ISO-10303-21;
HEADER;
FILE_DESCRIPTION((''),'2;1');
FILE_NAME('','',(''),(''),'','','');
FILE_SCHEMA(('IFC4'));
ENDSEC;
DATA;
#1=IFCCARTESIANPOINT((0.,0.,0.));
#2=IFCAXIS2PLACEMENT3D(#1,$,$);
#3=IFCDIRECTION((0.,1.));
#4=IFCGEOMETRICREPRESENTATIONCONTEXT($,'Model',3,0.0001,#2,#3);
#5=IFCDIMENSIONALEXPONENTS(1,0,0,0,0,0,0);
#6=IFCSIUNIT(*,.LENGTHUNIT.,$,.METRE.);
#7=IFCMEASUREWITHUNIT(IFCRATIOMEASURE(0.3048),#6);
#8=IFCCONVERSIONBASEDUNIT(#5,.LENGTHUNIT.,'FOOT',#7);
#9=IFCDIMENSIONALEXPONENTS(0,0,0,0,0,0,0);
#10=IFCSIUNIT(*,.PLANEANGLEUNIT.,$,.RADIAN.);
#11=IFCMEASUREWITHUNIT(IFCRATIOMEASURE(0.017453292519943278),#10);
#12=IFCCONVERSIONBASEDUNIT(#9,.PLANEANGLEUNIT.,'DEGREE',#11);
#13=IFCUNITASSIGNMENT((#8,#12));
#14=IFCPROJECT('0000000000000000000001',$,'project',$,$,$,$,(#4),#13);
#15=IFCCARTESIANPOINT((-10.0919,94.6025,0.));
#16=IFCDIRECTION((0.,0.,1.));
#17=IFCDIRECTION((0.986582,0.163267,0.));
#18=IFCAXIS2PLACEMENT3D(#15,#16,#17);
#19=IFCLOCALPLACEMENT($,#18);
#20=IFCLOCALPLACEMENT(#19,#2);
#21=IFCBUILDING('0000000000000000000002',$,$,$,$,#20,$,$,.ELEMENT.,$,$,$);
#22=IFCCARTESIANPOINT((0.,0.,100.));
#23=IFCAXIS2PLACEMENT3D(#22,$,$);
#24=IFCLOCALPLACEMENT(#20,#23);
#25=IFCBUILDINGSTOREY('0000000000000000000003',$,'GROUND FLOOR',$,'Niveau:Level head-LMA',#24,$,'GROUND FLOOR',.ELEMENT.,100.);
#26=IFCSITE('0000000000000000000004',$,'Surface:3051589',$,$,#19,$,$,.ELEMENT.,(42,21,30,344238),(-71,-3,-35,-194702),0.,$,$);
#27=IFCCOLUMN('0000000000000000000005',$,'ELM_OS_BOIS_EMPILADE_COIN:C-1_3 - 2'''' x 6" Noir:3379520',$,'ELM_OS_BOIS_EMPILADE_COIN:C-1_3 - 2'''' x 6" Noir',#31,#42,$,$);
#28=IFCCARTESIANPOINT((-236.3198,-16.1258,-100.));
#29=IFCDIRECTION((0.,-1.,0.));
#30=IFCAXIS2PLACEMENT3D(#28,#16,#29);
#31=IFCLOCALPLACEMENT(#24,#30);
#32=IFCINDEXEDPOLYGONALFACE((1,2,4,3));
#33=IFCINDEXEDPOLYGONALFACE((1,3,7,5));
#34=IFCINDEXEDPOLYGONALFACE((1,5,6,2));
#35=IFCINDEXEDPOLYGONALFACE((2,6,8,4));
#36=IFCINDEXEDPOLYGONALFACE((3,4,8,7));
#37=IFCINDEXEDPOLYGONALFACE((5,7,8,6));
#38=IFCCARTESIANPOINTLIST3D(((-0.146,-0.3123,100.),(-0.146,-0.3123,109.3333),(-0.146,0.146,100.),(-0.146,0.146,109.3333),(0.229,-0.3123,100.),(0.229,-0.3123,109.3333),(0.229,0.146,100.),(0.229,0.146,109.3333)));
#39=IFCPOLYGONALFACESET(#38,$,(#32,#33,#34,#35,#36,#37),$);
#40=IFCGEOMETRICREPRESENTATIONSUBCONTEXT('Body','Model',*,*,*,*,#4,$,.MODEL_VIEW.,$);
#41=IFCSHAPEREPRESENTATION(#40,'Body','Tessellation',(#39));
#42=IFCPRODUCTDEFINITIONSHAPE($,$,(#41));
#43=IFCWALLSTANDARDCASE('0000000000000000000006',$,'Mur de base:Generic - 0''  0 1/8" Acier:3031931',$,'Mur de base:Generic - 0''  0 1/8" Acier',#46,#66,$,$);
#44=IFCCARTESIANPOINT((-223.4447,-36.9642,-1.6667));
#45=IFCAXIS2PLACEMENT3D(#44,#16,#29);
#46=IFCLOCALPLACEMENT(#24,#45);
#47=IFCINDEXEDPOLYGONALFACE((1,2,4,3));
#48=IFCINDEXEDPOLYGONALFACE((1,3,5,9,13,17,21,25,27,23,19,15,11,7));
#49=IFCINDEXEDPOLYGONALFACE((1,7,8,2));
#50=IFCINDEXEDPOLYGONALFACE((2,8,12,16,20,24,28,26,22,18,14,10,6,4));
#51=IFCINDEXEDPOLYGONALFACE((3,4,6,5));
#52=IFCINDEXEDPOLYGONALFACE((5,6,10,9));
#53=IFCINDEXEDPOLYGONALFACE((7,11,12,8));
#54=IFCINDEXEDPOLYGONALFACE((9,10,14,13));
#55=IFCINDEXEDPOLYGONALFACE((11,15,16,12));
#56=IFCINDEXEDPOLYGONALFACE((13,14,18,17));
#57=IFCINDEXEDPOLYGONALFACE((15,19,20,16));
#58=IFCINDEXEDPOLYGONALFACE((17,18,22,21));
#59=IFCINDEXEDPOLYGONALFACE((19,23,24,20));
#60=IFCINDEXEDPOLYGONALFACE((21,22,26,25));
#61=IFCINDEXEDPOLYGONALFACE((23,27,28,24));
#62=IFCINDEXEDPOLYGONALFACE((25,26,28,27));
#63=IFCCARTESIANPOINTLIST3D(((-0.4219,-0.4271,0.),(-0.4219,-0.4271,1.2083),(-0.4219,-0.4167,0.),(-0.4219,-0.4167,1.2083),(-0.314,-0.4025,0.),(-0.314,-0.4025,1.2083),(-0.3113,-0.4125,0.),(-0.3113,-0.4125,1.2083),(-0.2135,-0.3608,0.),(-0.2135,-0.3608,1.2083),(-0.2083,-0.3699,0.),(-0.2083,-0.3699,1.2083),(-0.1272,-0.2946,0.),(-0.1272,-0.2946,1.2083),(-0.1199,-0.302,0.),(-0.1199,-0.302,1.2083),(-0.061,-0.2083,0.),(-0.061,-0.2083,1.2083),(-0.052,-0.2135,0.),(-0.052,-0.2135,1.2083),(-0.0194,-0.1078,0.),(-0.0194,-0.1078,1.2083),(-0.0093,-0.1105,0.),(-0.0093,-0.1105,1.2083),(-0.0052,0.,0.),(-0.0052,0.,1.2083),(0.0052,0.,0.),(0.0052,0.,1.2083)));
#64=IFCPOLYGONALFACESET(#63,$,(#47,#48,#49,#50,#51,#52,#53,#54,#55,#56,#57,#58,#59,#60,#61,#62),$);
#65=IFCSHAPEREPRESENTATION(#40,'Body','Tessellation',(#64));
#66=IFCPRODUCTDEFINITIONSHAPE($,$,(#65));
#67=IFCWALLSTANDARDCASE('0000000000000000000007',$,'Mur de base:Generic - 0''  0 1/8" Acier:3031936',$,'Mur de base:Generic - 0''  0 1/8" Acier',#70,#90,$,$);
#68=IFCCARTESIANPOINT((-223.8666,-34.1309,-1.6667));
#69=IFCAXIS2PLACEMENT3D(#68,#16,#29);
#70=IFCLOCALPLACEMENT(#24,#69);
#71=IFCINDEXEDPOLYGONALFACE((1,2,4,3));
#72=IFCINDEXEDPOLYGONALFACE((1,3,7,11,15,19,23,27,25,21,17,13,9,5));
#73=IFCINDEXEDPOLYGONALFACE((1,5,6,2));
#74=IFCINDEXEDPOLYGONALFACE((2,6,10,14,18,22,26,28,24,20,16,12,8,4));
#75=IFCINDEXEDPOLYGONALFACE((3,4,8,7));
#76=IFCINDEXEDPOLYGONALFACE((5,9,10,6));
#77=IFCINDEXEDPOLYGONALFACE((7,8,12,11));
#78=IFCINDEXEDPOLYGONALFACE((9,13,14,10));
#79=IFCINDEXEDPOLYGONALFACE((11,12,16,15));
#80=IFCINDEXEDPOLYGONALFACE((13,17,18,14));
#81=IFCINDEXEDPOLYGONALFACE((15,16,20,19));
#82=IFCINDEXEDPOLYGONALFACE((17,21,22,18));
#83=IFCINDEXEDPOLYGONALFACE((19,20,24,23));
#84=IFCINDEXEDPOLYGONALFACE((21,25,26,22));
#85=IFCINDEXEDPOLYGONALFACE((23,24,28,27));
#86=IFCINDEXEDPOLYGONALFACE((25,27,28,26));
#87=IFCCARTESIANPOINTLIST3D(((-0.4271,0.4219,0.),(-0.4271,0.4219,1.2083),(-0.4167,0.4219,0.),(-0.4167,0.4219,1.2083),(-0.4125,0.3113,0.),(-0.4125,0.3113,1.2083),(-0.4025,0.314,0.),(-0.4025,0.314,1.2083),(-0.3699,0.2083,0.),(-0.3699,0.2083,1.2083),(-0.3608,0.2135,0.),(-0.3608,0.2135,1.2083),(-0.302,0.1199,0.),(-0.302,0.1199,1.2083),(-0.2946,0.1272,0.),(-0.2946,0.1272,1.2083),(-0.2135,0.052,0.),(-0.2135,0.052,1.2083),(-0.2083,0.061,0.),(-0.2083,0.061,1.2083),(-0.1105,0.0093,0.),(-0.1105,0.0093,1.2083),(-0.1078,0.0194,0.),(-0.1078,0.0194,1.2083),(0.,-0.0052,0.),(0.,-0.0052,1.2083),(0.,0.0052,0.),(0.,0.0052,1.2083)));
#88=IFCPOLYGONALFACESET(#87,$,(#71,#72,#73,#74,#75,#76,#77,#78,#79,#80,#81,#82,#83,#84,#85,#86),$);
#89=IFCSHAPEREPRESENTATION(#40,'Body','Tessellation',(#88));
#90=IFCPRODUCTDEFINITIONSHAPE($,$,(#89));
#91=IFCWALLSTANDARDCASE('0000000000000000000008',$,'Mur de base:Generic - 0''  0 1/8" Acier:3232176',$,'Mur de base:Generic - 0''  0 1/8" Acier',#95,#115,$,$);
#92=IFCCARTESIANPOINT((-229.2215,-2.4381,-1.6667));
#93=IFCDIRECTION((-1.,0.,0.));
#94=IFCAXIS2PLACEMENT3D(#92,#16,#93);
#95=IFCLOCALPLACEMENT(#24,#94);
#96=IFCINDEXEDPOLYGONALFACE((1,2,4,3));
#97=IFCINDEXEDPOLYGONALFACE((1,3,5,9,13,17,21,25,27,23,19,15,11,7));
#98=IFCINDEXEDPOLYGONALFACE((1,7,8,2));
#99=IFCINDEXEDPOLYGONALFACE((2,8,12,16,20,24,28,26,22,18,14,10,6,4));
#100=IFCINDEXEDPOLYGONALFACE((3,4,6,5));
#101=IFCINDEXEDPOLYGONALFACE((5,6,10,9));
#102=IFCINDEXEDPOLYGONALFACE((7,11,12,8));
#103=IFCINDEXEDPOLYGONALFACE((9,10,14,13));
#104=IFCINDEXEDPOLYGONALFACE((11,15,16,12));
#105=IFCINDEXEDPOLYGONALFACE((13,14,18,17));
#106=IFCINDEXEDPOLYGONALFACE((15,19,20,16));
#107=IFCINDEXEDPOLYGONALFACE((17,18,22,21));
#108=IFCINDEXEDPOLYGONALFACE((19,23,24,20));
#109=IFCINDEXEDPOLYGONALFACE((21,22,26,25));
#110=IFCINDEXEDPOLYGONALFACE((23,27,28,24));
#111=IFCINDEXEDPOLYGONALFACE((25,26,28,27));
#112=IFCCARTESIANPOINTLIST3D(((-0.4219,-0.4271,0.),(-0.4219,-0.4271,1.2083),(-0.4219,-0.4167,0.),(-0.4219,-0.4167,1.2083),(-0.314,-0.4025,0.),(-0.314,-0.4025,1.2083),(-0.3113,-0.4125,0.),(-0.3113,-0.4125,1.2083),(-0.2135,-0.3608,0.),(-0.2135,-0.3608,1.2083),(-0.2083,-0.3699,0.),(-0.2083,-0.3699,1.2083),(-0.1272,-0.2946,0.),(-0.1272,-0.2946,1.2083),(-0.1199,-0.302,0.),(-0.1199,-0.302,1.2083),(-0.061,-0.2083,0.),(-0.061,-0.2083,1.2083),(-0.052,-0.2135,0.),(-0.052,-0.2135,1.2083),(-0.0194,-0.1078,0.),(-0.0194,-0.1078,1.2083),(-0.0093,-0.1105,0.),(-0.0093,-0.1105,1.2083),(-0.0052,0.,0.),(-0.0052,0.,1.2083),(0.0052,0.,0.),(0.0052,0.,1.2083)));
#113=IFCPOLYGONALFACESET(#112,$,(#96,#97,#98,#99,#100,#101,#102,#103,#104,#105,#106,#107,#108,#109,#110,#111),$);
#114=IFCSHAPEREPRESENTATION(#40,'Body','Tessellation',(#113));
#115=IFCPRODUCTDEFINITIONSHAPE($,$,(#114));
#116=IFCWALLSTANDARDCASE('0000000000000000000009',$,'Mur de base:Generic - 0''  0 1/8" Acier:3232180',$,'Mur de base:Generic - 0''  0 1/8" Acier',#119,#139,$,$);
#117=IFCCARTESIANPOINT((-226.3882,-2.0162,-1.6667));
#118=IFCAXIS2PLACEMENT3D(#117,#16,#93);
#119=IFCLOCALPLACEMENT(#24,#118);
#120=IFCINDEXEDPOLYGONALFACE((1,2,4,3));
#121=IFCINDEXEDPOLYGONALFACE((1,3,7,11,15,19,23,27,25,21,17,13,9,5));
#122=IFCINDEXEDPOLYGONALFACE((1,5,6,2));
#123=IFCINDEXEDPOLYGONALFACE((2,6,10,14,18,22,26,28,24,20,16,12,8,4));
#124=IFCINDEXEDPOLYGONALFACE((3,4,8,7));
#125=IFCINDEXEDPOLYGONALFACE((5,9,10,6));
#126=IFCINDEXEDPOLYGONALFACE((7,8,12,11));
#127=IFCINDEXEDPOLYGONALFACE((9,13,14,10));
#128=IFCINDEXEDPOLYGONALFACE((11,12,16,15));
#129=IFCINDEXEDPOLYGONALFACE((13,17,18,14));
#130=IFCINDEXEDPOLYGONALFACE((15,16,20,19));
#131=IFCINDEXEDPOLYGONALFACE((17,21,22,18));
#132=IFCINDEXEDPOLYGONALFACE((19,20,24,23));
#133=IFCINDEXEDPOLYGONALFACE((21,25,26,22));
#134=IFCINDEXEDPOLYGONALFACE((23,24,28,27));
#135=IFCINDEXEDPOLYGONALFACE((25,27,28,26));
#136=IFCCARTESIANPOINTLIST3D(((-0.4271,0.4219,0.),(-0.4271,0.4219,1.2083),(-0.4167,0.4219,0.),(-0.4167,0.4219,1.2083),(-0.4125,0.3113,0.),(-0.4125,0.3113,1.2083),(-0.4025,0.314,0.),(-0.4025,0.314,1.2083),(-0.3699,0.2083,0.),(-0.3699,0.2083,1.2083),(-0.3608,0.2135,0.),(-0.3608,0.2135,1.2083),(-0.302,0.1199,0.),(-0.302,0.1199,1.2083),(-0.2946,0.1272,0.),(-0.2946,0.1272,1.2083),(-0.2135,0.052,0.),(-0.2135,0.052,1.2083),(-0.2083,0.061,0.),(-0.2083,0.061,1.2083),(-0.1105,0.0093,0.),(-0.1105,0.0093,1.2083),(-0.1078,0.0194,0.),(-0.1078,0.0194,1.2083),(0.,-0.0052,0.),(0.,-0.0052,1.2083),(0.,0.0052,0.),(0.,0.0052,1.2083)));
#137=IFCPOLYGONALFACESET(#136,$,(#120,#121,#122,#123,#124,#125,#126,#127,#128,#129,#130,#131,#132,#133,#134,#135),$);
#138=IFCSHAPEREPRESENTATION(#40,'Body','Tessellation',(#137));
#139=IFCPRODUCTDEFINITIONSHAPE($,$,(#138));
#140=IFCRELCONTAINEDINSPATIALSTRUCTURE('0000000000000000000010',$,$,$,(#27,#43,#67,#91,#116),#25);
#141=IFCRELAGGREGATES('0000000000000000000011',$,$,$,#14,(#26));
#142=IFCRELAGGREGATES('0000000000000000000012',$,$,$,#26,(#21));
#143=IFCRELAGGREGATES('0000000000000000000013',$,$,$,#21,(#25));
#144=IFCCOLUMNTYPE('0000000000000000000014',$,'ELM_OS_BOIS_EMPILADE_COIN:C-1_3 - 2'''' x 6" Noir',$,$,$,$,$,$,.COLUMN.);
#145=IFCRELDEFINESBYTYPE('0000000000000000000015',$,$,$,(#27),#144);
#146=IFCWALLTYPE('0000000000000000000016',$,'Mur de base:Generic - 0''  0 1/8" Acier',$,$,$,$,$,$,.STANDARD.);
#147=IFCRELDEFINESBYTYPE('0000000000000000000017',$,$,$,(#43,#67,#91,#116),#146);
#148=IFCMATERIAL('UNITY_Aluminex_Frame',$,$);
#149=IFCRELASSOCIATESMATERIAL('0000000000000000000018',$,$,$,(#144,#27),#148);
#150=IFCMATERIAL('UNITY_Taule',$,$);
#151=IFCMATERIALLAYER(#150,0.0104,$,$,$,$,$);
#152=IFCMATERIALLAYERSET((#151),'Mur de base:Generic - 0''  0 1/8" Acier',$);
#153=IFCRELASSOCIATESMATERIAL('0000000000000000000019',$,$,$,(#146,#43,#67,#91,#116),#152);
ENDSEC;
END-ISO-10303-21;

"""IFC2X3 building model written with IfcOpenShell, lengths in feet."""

from ifc_helpers import new_model, entity, si_unit, converted_unit, direction, frame, frame_2d, origin, origin_2d_with_axis, place, context, subcontext, project, spatial, polyline, circle_curve, parameter, trimmed, segment, composite_curve, rectangle, outline, extrude, source, transform, mapped, material, layer, layer_set, layer_usage, type_object, type_shapes, element, save


model = new_model("IFC2X3")

# Units and contexts
model_context = context("Model", 3, precision=0.0001, world=origin(), true_north=direction((0.0, 1.0)))
body_context = subcontext(model_context, "Body", "Model", "MODEL_VIEW")
ifc_project = project(units=[converted_unit("LENGTHUNIT", "FOOT", entity("IfcRatioMeasure", 0.3048), si_unit("LENGTHUNIT", "METRE"), dimensions=[1, 0, 0, 0, 0, 0, 0]), converted_unit("PLANEANGLEUNIT", "DEGREE", entity("IfcRatioMeasure", 0.017453292519943278), si_unit("PLANEANGLEUNIT", "RADIAN"), dimensions=[0, 0, 0, 0, 0, 0, 0])], contexts=[model_context])

# Site, building, storey
site_placement = place(None, frame((-10.0919, 94.6025, 0.0), z_axis=(0.0, 0.0, 1.0), x_axis=(0.986582, 0.163267, 0.0)))
site = spatial("IfcSite", under=ifc_project, at=site_placement, Name="Surface:3051589", CompositionType="ELEMENT", RefLatitude=(42, 21, 30, 344238), RefLongitude=(-71, -3, -35, -194702), RefElevation=0.0)
building_placement = place(site_placement, origin())
building = spatial("IfcBuilding", under=site, at=building_placement, CompositionType="ELEMENT")
storey_placement = place(building_placement, frame((0.0, 0.0, 100.0)))
storey = spatial("IfcBuildingStorey", under=building, at=storey_placement, Name="GROUND FLOOR", ObjectType="Niveau:Level head-LMA", LongName="GROUND FLOOR", CompositionType="ELEMENT", Elevation=100.0)

# Column
ifc_material_1 = material(Name="UNITY_Aluminex_Frame")
column_type = type_object("IfcColumnType", Name="ELM_OS_BOIS_EMPILADE_COIN:C-1_3 - 2'' x 6\" Noir", PredefinedType="COLUMN", material=ifc_material_1)
shared_shape = source(origin(), body_context, "Body", "SweptSolid", [
    extrude(rectangle(XDim=0.4583, YDim=0.375, at=origin_2d_with_axis()), frame((0.0415, -0.0832, 100.0), z_axis=(0.0, 0.0, 1.0), x_axis=(0.0, -1.0, 0.0)), (0.0, 0.0, 1.0), 9.3333),
])
type_shapes(column_type, [shared_shape])
column_placement = place(storey_placement, frame((-236.3198, -16.1258, -100.0), z_axis=(0.0, 0.0, 1.0), x_axis=(0.0, -1.0, 0.0)))
element("IfcColumn", 1, at=column_placement, inside=storey, type_object=column_type, material=ifc_material_1, Name="ELM_OS_BOIS_EMPILADE_COIN:C-1_3 - 2'' x 6\" Noir:3379520", ObjectType="ELM_OS_BOIS_EMPILADE_COIN:C-1_3 - 2'' x 6\" Noir", context=body_context, shape_type="MappedRepresentation", body=[
    mapped(shared_shape, transform((0.0, 0.0, 0.0), scale=1.0)),
])

# Walls
ifc_material_2 = material(Name="UNITY_Taule")
ifc_layer_1 = layer(ifc_material_2, 0.0104)
ifc_layer_set_1 = layer_set([ifc_layer_1], Name="Mur de base:Generic - 0'  0 1/8\" Acier")
ifc_layer_usage_1 = layer_usage(ifc_layer_set_1, "AXIS2", "NEGATIVE", 0.0052)
wall_type_1 = type_object("IfcWallType", Name="Mur de base:Generic - 0'  0 1/8\" Acier", PredefinedType="STANDARD", material=ifc_layer_set_1)
wall_1_placement = place(storey_placement, frame((-223.4447, -36.9642, -1.6667), z_axis=(0.0, 0.0, 1.0), x_axis=(0.0, -1.0, 0.0)))
element("IfcWallStandardCase", 2, at=wall_1_placement, inside=storey, type_object=wall_type_1, material=ifc_layer_usage_1, Name="Mur de base:Generic - 0'  0 1/8\" Acier:3031931", ObjectType="Mur de base:Generic - 0'  0 1/8\" Acier", context=body_context, shape_type="SweptSolid", body=[
    extrude(outline(composite_curve([segment(trimmed(circle_curve(frame_2d((-0.4219, 0.0), x_axis=(1.0, 0.0)), 0.4271), [parameter(270.0)], [parameter(0.0)], True, "PARAMETER"), True, "CONTINUOUS"), segment(polyline([(0.0052, 0.0), (-0.0052, 0.0)]), True, "CONTINUOUS"), segment(trimmed(circle_curve(frame_2d((-0.4219, 0.0), x_axis=(1.0, 0.0)), 0.4167), [parameter(270.0)], [parameter(0.0)], True, "PARAMETER"), False, "CONTINUOUS"), segment(polyline([(-0.4219, -0.4167), (-0.4219, -0.4271)]), True, "CONTINUOUS")], self_intersect=False)), origin(), (0.0, 0.0, 1.0), 1.2083),
])
ifc_layer_usage_2 = layer_usage(ifc_layer_set_1, "AXIS2", "NEGATIVE", 0.0052)
wall_2_placement = place(storey_placement, frame((-223.8666, -34.1309, -1.6667), z_axis=(0.0, 0.0, 1.0), x_axis=(0.0, -1.0, 0.0)))
element("IfcWallStandardCase", 3, at=wall_2_placement, inside=storey, type_object=wall_type_1, material=ifc_layer_usage_2, Name="Mur de base:Generic - 0'  0 1/8\" Acier:3031936", ObjectType="Mur de base:Generic - 0'  0 1/8\" Acier", context=body_context, shape_type="SweptSolid", body=[
    extrude(outline(composite_curve([segment(trimmed(circle_curve(frame_2d((0.0, 0.4219), x_axis=(1.0, 0.0)), 0.4271), [parameter(180.0)], [parameter(270.0)], True, "PARAMETER"), True, "CONTINUOUS"), segment(polyline([(0.0, -0.0052), (0.0, 0.0052)]), True, "CONTINUOUS"), segment(trimmed(circle_curve(frame_2d((0.0, 0.4219), x_axis=(1.0, 0.0)), 0.4167), [parameter(180.0)], [parameter(270.0)], True, "PARAMETER"), False, "CONTINUOUS"), segment(polyline([(-0.4167, 0.4219), (-0.4271, 0.4219)]), True, "CONTINUOUS")], self_intersect=False)), origin(), (0.0, 0.0, 1.0), 1.2083),
])
ifc_layer_usage_3 = layer_usage(ifc_layer_set_1, "AXIS2", "NEGATIVE", 0.0052)
wall_3_placement = place(storey_placement, frame((-229.2215, -2.4381, -1.6667), z_axis=(0.0, 0.0, 1.0), x_axis=(-1.0, 0.0, 0.0)))
element("IfcWallStandardCase", 4, at=wall_3_placement, inside=storey, type_object=wall_type_1, material=ifc_layer_usage_3, Name="Mur de base:Generic - 0'  0 1/8\" Acier:3232176", ObjectType="Mur de base:Generic - 0'  0 1/8\" Acier", context=body_context, shape_type="SweptSolid", body=[
    extrude(outline(composite_curve([segment(trimmed(circle_curve(frame_2d((-0.4219, 0.0), x_axis=(1.0, 0.0)), 0.4271), [parameter(270.0)], [parameter(0.0)], True, "PARAMETER"), True, "CONTINUOUS"), segment(polyline([(0.0052, 0.0), (-0.0052, 0.0)]), True, "CONTINUOUS"), segment(trimmed(circle_curve(frame_2d((-0.4219, 0.0), x_axis=(1.0, 0.0)), 0.4167), [parameter(270.0)], [parameter(0.0)], True, "PARAMETER"), False, "CONTINUOUS"), segment(polyline([(-0.4219, -0.4167), (-0.4219, -0.4271)]), True, "CONTINUOUS")], self_intersect=False)), origin(), (0.0, 0.0, 1.0), 1.2083),
])
ifc_layer_usage_4 = layer_usage(ifc_layer_set_1, "AXIS2", "NEGATIVE", 0.0052)
wall_4_placement = place(storey_placement, frame((-226.3882, -2.0162, -1.6667), z_axis=(0.0, 0.0, 1.0), x_axis=(-1.0, 0.0, 0.0)))
element("IfcWallStandardCase", 5, at=wall_4_placement, inside=storey, type_object=wall_type_1, material=ifc_layer_usage_4, Name="Mur de base:Generic - 0'  0 1/8\" Acier:3232180", ObjectType="Mur de base:Generic - 0'  0 1/8\" Acier", context=body_context, shape_type="SweptSolid", body=[
    extrude(outline(composite_curve([segment(trimmed(circle_curve(frame_2d((0.0, 0.4219), x_axis=(1.0, 0.0)), 0.4271), [parameter(180.0)], [parameter(270.0)], True, "PARAMETER"), True, "CONTINUOUS"), segment(polyline([(0.0, -0.0052), (0.0, 0.0052)]), True, "CONTINUOUS"), segment(trimmed(circle_curve(frame_2d((0.0, 0.4219), x_axis=(1.0, 0.0)), 0.4167), [parameter(180.0)], [parameter(270.0)], True, "PARAMETER"), False, "CONTINUOUS"), segment(polyline([(-0.4167, 0.4219), (-0.4271, 0.4219)]), True, "CONTINUOUS")], self_intersect=False)), origin(), (0.0, 0.0, 1.0), 1.2083),
])

save(model, "model.ifc")
